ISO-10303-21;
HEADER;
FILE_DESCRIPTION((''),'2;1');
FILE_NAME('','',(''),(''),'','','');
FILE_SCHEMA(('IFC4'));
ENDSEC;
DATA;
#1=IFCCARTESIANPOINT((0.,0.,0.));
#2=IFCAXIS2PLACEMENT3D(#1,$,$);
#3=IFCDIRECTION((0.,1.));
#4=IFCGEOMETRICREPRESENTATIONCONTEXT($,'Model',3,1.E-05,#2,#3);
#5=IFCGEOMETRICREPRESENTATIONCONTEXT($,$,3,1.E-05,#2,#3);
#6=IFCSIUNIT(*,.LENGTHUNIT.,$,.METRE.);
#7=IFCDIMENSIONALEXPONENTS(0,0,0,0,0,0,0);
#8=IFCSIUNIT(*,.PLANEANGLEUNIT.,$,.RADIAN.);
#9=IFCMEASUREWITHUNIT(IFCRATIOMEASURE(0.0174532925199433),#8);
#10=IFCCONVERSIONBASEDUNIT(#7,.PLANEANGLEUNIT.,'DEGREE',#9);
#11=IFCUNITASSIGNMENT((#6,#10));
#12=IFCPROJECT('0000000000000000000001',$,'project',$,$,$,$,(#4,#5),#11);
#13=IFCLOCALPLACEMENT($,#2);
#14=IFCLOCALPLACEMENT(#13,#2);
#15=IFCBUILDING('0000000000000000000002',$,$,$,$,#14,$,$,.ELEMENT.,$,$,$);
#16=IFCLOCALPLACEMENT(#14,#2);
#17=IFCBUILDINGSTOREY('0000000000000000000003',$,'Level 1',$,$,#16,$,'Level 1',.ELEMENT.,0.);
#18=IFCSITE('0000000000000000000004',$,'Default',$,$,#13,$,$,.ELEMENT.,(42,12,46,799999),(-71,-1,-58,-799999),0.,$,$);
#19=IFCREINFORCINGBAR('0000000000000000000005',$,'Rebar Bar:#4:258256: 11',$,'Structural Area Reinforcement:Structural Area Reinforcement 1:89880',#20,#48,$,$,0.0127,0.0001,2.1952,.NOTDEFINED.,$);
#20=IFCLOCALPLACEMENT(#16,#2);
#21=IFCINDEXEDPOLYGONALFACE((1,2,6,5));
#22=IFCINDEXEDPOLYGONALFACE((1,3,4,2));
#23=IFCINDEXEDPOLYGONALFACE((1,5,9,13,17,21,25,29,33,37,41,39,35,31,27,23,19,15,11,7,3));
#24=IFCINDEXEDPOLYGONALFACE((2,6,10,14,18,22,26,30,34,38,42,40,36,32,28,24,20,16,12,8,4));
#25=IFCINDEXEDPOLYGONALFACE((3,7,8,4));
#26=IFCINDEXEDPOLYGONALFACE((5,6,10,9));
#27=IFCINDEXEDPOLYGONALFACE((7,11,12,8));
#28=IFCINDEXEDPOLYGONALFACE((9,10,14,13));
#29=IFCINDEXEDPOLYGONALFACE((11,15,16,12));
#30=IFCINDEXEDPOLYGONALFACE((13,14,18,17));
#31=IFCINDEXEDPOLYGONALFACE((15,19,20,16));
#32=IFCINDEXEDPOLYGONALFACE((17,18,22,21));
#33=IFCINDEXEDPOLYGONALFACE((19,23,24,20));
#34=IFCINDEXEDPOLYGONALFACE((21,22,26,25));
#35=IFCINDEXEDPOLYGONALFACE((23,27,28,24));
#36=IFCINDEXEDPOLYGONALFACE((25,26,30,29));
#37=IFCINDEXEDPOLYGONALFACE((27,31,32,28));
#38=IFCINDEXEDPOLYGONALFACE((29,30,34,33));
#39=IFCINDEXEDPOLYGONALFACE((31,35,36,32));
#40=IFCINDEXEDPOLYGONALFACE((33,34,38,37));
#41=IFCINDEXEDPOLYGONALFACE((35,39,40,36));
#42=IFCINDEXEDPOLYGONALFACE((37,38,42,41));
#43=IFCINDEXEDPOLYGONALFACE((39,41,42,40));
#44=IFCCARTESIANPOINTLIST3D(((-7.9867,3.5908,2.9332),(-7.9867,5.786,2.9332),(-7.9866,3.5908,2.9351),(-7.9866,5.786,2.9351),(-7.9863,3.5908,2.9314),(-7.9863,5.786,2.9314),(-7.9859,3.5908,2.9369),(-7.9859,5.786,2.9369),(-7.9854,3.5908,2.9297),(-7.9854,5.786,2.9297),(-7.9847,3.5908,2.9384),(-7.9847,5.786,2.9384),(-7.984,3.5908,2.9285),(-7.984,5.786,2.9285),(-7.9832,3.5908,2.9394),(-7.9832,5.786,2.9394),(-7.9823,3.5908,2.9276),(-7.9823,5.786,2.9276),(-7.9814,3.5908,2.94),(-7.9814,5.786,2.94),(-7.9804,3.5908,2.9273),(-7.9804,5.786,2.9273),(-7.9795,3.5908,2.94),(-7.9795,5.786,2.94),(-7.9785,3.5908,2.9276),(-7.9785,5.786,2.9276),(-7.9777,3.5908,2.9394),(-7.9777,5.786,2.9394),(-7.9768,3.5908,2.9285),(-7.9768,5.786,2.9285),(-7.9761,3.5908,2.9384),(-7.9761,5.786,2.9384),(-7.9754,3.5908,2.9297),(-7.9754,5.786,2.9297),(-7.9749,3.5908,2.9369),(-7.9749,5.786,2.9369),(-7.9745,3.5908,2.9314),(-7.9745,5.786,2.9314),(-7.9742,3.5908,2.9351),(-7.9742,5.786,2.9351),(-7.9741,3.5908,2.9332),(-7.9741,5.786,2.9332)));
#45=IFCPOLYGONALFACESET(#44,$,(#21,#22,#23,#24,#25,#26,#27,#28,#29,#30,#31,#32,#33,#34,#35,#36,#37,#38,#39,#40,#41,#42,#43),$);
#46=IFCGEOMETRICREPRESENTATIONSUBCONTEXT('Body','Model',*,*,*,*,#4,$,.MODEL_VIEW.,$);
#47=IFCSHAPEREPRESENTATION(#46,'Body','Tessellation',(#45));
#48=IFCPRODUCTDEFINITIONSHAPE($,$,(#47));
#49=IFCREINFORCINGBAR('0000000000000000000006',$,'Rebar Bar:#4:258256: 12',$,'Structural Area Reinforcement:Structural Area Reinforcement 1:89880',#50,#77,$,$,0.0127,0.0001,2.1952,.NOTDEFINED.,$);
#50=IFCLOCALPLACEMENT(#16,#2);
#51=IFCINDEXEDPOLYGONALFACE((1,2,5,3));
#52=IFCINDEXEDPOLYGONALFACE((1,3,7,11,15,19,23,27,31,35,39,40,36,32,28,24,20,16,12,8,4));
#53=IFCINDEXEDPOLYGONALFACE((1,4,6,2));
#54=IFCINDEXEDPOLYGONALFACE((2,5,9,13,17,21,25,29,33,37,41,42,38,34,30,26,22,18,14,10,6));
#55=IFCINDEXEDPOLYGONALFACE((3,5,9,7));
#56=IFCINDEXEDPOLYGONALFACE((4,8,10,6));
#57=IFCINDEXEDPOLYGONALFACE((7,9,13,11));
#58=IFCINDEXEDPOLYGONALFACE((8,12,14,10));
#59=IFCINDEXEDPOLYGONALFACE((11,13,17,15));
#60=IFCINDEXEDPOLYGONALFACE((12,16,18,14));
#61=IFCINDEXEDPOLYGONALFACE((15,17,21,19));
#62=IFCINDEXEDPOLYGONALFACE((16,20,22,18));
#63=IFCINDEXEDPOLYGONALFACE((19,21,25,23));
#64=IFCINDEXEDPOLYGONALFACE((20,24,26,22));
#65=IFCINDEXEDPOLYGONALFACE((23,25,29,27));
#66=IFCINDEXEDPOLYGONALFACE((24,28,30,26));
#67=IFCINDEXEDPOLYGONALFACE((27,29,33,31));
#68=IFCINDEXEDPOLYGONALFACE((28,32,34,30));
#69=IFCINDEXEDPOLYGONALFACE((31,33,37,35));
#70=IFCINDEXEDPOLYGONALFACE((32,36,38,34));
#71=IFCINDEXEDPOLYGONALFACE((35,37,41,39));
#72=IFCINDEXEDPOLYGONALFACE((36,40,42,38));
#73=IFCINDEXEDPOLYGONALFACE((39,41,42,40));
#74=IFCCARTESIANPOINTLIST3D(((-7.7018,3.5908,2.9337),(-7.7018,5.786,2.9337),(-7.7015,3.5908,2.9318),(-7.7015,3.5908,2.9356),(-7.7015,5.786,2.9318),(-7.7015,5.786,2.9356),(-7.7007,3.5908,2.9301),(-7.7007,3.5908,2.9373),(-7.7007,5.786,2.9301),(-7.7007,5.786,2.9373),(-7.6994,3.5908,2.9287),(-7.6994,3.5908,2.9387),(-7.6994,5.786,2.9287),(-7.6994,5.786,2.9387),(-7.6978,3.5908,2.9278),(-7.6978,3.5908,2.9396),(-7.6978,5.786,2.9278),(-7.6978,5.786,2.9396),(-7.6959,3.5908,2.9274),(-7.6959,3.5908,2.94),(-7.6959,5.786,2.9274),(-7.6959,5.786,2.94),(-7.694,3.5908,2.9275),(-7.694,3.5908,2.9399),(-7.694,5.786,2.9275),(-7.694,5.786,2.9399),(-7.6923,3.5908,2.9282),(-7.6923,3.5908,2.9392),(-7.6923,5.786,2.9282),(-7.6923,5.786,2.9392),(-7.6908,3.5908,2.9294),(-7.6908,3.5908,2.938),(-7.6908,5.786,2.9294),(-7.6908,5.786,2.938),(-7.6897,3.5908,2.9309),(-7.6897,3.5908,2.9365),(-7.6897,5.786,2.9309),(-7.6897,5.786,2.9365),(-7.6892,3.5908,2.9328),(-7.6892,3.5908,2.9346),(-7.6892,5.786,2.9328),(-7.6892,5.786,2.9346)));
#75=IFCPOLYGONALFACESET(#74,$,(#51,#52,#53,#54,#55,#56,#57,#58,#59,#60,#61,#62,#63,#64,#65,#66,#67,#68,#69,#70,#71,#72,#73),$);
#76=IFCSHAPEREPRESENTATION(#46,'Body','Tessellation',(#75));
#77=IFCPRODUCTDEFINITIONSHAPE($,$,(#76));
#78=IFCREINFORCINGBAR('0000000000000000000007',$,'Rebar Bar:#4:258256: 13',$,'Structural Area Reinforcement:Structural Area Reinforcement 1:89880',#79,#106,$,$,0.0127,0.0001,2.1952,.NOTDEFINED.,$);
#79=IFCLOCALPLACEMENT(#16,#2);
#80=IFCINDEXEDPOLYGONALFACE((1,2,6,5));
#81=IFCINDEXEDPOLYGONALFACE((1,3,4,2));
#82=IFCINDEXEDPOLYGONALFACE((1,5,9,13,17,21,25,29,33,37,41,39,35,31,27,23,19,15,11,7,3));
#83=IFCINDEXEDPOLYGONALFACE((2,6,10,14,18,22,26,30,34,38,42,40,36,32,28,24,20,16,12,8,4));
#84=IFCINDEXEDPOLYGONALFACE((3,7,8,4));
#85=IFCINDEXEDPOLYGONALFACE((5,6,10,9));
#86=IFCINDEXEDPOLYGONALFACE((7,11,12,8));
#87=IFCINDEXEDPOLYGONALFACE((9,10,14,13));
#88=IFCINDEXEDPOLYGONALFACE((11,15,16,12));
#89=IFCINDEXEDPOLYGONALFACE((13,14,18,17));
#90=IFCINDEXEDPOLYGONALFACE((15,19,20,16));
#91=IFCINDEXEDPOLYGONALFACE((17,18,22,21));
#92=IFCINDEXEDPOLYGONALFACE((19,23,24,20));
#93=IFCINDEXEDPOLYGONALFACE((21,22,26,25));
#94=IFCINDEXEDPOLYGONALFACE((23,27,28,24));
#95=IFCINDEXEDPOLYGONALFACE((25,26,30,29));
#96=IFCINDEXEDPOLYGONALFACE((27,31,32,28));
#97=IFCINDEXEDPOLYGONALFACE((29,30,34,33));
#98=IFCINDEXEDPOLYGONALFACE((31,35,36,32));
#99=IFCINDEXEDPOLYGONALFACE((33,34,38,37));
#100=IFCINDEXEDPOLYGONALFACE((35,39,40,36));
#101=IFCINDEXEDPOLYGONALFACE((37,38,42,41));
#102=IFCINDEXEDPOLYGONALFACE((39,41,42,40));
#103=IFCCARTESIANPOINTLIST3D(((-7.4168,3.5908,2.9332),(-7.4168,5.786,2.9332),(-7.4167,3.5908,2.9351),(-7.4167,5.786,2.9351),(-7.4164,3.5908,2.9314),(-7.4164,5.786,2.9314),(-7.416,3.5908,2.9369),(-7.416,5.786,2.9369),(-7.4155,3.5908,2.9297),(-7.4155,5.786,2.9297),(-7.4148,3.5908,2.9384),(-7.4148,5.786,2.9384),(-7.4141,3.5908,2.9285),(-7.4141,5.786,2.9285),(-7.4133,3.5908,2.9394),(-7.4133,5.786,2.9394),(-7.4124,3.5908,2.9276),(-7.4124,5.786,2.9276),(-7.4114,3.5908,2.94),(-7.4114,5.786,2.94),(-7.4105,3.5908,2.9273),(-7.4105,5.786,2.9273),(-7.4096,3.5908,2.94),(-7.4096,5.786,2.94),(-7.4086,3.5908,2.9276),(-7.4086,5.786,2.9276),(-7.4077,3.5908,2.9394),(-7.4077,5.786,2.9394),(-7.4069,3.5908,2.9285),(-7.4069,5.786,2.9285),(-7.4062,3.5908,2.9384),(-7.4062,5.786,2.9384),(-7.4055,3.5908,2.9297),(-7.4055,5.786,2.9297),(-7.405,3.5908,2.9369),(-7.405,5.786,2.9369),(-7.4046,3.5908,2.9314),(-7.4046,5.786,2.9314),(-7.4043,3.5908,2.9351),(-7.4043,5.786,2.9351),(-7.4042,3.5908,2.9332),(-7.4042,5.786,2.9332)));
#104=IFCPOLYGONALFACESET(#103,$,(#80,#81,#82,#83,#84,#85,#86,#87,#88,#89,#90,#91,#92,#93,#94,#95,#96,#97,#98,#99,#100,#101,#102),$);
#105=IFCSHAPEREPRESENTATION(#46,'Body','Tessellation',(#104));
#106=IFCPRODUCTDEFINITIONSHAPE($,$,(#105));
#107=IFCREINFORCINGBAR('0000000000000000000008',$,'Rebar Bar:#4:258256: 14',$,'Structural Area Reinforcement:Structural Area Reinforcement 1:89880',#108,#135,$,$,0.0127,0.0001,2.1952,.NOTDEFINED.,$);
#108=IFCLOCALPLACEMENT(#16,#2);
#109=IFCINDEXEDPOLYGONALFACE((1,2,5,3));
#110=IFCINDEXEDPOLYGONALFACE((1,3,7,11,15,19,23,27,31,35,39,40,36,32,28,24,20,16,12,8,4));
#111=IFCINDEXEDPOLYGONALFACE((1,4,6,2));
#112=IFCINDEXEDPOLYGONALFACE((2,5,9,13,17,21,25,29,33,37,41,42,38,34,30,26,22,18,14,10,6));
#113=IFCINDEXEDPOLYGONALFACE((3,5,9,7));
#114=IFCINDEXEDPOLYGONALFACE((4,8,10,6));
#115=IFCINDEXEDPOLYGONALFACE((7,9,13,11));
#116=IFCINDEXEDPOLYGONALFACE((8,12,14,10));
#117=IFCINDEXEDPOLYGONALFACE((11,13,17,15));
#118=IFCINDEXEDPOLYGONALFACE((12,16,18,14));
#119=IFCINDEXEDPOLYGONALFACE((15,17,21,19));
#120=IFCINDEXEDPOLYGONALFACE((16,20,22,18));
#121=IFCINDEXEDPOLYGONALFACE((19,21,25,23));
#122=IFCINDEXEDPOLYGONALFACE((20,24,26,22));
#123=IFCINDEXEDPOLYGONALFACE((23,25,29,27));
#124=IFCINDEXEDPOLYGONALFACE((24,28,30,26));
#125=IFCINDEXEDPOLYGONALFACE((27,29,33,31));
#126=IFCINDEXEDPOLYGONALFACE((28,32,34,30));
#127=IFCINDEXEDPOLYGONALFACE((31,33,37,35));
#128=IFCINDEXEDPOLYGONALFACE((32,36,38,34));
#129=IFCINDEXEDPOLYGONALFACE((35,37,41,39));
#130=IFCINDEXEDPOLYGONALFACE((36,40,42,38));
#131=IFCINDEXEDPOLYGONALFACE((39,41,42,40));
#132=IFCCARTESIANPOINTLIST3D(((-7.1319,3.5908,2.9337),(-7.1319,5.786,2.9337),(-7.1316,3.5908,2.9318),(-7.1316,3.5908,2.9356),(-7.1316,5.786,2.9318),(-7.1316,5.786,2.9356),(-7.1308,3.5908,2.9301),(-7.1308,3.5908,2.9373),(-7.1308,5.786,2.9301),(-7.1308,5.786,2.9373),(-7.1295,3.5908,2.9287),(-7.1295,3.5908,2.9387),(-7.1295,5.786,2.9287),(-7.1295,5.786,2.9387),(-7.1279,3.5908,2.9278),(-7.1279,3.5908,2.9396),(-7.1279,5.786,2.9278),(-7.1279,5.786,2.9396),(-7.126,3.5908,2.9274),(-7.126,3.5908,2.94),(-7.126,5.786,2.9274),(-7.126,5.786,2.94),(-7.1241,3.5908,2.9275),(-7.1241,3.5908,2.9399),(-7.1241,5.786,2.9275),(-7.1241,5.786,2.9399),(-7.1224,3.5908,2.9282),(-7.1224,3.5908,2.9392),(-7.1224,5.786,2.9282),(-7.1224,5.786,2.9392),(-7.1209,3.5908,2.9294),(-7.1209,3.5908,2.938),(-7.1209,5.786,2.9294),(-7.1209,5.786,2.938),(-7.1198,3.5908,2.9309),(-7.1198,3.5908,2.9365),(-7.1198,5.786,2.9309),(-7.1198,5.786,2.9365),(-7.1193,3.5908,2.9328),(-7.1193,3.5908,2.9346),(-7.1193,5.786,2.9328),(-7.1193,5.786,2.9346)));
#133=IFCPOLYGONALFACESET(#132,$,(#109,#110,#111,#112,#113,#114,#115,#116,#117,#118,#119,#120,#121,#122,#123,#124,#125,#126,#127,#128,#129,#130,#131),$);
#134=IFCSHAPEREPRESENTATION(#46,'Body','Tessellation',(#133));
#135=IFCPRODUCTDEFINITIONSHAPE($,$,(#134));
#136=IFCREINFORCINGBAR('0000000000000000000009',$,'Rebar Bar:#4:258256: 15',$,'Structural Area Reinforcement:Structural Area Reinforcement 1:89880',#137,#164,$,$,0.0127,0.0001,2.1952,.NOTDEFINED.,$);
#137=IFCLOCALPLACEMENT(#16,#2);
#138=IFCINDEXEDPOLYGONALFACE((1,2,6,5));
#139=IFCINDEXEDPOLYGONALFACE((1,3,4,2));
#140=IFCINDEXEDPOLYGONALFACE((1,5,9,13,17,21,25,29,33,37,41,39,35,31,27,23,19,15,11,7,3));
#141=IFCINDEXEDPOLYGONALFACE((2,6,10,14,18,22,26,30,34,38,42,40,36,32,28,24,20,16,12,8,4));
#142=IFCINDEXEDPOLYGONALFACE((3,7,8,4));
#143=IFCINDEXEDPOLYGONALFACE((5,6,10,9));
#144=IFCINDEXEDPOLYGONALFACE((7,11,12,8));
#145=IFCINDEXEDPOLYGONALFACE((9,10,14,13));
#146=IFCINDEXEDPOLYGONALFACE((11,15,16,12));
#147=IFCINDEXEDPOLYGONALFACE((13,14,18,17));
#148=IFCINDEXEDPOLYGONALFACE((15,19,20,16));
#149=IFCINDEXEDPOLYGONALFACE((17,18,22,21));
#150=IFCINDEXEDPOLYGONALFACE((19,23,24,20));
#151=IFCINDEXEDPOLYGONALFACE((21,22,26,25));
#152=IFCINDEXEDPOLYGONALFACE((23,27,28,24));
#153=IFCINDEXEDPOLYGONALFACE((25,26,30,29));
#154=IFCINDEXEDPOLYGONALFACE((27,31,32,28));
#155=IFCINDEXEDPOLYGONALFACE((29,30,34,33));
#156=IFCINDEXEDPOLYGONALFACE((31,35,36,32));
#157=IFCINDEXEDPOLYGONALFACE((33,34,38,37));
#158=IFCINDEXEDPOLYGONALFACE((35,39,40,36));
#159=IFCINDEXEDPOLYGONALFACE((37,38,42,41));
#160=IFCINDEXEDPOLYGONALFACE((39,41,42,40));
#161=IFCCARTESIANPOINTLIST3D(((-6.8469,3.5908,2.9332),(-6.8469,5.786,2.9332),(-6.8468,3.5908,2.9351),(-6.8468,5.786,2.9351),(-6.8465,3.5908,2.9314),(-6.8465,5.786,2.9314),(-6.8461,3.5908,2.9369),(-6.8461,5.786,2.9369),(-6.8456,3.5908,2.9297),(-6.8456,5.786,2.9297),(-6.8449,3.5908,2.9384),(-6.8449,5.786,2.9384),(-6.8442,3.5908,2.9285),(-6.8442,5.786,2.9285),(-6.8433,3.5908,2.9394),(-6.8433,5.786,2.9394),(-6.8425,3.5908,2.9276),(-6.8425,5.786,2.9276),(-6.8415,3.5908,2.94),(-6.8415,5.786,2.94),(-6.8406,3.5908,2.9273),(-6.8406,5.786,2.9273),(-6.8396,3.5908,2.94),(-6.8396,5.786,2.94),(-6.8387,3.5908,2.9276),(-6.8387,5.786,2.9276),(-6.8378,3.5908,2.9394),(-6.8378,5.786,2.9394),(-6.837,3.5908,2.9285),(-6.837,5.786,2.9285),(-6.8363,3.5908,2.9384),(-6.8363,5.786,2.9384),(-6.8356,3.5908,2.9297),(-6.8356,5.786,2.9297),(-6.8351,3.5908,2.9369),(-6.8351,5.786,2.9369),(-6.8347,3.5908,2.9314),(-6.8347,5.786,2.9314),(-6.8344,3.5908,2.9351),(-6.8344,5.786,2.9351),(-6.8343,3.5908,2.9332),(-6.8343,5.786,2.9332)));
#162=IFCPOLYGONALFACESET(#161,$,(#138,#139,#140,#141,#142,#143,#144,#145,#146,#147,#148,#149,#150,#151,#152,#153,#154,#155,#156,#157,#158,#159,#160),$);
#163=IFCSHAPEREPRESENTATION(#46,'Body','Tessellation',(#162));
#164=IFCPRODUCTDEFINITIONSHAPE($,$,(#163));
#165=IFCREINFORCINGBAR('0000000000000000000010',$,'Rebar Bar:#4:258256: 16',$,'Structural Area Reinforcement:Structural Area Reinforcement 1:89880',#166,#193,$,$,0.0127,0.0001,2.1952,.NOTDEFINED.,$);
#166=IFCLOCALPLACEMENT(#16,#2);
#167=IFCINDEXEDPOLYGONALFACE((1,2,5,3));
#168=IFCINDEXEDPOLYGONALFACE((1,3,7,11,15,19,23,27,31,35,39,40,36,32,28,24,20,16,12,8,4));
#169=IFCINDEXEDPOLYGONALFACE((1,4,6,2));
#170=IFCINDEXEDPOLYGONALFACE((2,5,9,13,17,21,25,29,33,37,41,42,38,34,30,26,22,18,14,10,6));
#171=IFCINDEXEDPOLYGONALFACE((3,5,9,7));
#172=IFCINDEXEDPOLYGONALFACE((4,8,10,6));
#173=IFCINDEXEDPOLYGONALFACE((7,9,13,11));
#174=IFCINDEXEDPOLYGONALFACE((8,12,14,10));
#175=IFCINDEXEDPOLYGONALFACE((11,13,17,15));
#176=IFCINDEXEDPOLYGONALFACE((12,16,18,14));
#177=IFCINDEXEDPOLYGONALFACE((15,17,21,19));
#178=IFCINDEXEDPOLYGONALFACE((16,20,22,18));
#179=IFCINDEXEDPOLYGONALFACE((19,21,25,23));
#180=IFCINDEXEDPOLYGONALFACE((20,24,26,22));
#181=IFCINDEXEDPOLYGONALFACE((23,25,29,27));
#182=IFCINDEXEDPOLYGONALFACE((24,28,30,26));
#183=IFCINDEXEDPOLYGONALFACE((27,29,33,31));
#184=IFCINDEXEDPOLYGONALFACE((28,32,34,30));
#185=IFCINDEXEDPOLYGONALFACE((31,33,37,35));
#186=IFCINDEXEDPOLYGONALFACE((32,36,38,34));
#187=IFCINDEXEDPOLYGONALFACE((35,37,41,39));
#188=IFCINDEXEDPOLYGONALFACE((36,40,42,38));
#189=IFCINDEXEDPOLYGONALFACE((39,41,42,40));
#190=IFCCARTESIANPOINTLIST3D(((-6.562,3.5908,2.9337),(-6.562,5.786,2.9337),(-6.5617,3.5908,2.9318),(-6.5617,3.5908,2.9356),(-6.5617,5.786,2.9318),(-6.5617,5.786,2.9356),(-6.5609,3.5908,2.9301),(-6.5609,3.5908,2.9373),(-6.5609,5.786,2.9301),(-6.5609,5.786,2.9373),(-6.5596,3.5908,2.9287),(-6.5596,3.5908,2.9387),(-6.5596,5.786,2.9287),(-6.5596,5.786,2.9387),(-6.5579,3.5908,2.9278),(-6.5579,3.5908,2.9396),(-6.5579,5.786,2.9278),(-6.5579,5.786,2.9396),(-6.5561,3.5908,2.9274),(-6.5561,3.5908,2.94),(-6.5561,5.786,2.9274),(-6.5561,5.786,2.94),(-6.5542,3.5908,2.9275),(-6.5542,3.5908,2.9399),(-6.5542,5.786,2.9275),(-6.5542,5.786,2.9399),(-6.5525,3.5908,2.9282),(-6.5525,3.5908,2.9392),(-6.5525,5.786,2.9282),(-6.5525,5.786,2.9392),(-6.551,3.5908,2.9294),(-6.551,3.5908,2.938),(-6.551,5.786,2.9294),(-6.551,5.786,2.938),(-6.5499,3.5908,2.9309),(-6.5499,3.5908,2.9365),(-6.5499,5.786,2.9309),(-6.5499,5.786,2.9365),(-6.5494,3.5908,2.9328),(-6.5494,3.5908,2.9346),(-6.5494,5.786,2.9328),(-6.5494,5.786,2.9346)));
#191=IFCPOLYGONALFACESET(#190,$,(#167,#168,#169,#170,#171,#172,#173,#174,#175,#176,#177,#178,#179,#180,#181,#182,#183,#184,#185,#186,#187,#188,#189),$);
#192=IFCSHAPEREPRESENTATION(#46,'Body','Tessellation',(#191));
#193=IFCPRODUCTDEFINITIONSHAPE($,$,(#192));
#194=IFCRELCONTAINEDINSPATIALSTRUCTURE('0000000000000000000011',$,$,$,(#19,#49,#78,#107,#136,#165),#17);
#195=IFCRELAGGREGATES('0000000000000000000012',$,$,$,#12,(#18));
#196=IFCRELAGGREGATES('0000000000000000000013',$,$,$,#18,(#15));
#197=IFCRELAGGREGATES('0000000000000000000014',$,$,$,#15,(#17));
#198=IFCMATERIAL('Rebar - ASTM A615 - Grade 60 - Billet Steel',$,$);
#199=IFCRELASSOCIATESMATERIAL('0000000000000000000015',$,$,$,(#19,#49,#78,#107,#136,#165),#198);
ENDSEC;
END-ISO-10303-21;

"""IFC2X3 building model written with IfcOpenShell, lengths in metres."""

from ifc_helpers import new_model, entity, si_unit, converted_unit, direction, origin, place, context, subcontext, project, spatial, material, element, save


model = new_model("IFC2X3")

# Units and contexts
model_context = context("Model", 3, precision=1e-05, world=origin(), true_north=direction((0.0, 1.0)))
context_of_model = context(None, 3, precision=1e-05, world=origin(), true_north=direction((0.0, 1.0)))
body_context = subcontext(model_context, "Body", "Model", "MODEL_VIEW")
ifc_project = project(units=[si_unit("LENGTHUNIT", "METRE"), converted_unit("PLANEANGLEUNIT", "DEGREE", entity("IfcRatioMeasure", 0.0174532925199433), si_unit("PLANEANGLEUNIT", "RADIAN"), dimensions=[0, 0, 0, 0, 0, 0, 0])], contexts=[model_context, context_of_model])

# Site, building, storey
site_placement = place(None, origin())
site = spatial("IfcSite", under=ifc_project, at=site_placement, Name="Default", CompositionType="ELEMENT", RefLatitude=(42, 12, 46, 799999), RefLongitude=(-71, -1, -58, -799999), RefElevation=0.0)
building_placement = place(site_placement, origin())
building = spatial("IfcBuilding", under=site, at=building_placement, CompositionType="ELEMENT")
storey_placement = place(building_placement, origin())
storey = spatial("IfcBuildingStorey", under=building, at=storey_placement, Name="Level 1", LongName="Level 1", CompositionType="ELEMENT", Elevation=0.0)

# Reinforcing bars
ifc_material_1 = material(Name="Rebar - ASTM A615 - Grade 60 - Billet Steel")
reinforcing_bar_1_placement = place(storey_placement, origin())
element("IfcReinforcingBar", 1, at=reinforcing_bar_1_placement, inside=storey, material=ifc_material_1, Name="Rebar Bar:#4:258256: 11", ObjectType="Structural Area Reinforcement:Structural Area Reinforcement 1:89880", BarLength=2.1952, BarRole="NOTDEFINED", CrossSectionArea=0.0001, NominalDiameter=0.0127, context=body_context, shape_type="AdvancedSweptSolid", body=[
    entity("IfcSweptDiskSolid", entity("IfcCompositeCurve", [entity("IfcCompositeCurveSegment", "CONTINUOUS", True, entity("IfcPolyline", [entity("IfcCartesianPoint", [-7.9804, 5.786, 2.9337]), entity("IfcCartesianPoint", [-7.9804, 3.5908, 2.9337])]))], False), 0.0063, None, 0.0, 1.0),
])
reinforcing_bar_2_placement = place(storey_placement, origin())
element("IfcReinforcingBar", 2, at=reinforcing_bar_2_placement, inside=storey, material=ifc_material_1, Name="Rebar Bar:#4:258256: 12", ObjectType="Structural Area Reinforcement:Structural Area Reinforcement 1:89880", BarLength=2.1952, BarRole="NOTDEFINED", CrossSectionArea=0.0001, NominalDiameter=0.0127, context=body_context, shape_type="AdvancedSweptSolid", body=[
    entity("IfcSweptDiskSolid", entity("IfcCompositeCurve", [entity("IfcCompositeCurveSegment", "CONTINUOUS", True, entity("IfcPolyline", [entity("IfcCartesianPoint", [-7.6955, 5.786, 2.9337]), entity("IfcCartesianPoint", [-7.6955, 3.5908, 2.9337])]))], False), 0.0063, None, 0.0, 1.0),
])
reinforcing_bar_3_placement = place(storey_placement, origin())
element("IfcReinforcingBar", 3, at=reinforcing_bar_3_placement, inside=storey, material=ifc_material_1, Name="Rebar Bar:#4:258256: 13", ObjectType="Structural Area Reinforcement:Structural Area Reinforcement 1:89880", BarLength=2.1952, BarRole="NOTDEFINED", CrossSectionArea=0.0001, NominalDiameter=0.0127, context=body_context, shape_type="AdvancedSweptSolid", body=[
    entity("IfcSweptDiskSolid", entity("IfcCompositeCurve", [entity("IfcCompositeCurveSegment", "CONTINUOUS", True, entity("IfcPolyline", [entity("IfcCartesianPoint", [-7.4105, 5.786, 2.9337]), entity("IfcCartesianPoint", [-7.4105, 3.5908, 2.9337])]))], False), 0.0063, None, 0.0, 1.0),
])
reinforcing_bar_4_placement = place(storey_placement, origin())
element("IfcReinforcingBar", 4, at=reinforcing_bar_4_placement, inside=storey, material=ifc_material_1, Name="Rebar Bar:#4:258256: 14", ObjectType="Structural Area Reinforcement:Structural Area Reinforcement 1:89880", BarLength=2.1952, BarRole="NOTDEFINED", CrossSectionArea=0.0001, NominalDiameter=0.0127, context=body_context, shape_type="AdvancedSweptSolid", body=[
    entity("IfcSweptDiskSolid", entity("IfcCompositeCurve", [entity("IfcCompositeCurveSegment", "CONTINUOUS", True, entity("IfcPolyline", [entity("IfcCartesianPoint", [-7.1255, 5.786, 2.9337]), entity("IfcCartesianPoint", [-7.1255, 3.5908, 2.9337])]))], False), 0.0063, None, 0.0, 1.0),
])
reinforcing_bar_5_placement = place(storey_placement, origin())
element("IfcReinforcingBar", 5, at=reinforcing_bar_5_placement, inside=storey, material=ifc_material_1, Name="Rebar Bar:#4:258256: 15", ObjectType="Structural Area Reinforcement:Structural Area Reinforcement 1:89880", BarLength=2.1952, BarRole="NOTDEFINED", CrossSectionArea=0.0001, NominalDiameter=0.0127, context=body_context, shape_type="AdvancedSweptSolid", body=[
    entity("IfcSweptDiskSolid", entity("IfcCompositeCurve", [entity("IfcCompositeCurveSegment", "CONTINUOUS", True, entity("IfcPolyline", [entity("IfcCartesianPoint", [-6.8406, 5.786, 2.9337]), entity("IfcCartesianPoint", [-6.8406, 3.5908, 2.9337])]))], False), 0.0063, None, 0.0, 1.0),
])
reinforcing_bar_6_placement = place(storey_placement, origin())
element("IfcReinforcingBar", 6, at=reinforcing_bar_6_placement, inside=storey, material=ifc_material_1, Name="Rebar Bar:#4:258256: 16", ObjectType="Structural Area Reinforcement:Structural Area Reinforcement 1:89880", BarLength=2.1952, BarRole="NOTDEFINED", CrossSectionArea=0.0001, NominalDiameter=0.0127, context=body_context, shape_type="AdvancedSweptSolid", body=[
    entity("IfcSweptDiskSolid", entity("IfcCompositeCurve", [entity("IfcCompositeCurveSegment", "CONTINUOUS", True, entity("IfcPolyline", [entity("IfcCartesianPoint", [-6.5556, 5.786, 2.9337]), entity("IfcCartesianPoint", [-6.5556, 3.5908, 2.9337])]))], False), 0.0063, None, 0.0, 1.0),
])

save(model, "model.ifc")
